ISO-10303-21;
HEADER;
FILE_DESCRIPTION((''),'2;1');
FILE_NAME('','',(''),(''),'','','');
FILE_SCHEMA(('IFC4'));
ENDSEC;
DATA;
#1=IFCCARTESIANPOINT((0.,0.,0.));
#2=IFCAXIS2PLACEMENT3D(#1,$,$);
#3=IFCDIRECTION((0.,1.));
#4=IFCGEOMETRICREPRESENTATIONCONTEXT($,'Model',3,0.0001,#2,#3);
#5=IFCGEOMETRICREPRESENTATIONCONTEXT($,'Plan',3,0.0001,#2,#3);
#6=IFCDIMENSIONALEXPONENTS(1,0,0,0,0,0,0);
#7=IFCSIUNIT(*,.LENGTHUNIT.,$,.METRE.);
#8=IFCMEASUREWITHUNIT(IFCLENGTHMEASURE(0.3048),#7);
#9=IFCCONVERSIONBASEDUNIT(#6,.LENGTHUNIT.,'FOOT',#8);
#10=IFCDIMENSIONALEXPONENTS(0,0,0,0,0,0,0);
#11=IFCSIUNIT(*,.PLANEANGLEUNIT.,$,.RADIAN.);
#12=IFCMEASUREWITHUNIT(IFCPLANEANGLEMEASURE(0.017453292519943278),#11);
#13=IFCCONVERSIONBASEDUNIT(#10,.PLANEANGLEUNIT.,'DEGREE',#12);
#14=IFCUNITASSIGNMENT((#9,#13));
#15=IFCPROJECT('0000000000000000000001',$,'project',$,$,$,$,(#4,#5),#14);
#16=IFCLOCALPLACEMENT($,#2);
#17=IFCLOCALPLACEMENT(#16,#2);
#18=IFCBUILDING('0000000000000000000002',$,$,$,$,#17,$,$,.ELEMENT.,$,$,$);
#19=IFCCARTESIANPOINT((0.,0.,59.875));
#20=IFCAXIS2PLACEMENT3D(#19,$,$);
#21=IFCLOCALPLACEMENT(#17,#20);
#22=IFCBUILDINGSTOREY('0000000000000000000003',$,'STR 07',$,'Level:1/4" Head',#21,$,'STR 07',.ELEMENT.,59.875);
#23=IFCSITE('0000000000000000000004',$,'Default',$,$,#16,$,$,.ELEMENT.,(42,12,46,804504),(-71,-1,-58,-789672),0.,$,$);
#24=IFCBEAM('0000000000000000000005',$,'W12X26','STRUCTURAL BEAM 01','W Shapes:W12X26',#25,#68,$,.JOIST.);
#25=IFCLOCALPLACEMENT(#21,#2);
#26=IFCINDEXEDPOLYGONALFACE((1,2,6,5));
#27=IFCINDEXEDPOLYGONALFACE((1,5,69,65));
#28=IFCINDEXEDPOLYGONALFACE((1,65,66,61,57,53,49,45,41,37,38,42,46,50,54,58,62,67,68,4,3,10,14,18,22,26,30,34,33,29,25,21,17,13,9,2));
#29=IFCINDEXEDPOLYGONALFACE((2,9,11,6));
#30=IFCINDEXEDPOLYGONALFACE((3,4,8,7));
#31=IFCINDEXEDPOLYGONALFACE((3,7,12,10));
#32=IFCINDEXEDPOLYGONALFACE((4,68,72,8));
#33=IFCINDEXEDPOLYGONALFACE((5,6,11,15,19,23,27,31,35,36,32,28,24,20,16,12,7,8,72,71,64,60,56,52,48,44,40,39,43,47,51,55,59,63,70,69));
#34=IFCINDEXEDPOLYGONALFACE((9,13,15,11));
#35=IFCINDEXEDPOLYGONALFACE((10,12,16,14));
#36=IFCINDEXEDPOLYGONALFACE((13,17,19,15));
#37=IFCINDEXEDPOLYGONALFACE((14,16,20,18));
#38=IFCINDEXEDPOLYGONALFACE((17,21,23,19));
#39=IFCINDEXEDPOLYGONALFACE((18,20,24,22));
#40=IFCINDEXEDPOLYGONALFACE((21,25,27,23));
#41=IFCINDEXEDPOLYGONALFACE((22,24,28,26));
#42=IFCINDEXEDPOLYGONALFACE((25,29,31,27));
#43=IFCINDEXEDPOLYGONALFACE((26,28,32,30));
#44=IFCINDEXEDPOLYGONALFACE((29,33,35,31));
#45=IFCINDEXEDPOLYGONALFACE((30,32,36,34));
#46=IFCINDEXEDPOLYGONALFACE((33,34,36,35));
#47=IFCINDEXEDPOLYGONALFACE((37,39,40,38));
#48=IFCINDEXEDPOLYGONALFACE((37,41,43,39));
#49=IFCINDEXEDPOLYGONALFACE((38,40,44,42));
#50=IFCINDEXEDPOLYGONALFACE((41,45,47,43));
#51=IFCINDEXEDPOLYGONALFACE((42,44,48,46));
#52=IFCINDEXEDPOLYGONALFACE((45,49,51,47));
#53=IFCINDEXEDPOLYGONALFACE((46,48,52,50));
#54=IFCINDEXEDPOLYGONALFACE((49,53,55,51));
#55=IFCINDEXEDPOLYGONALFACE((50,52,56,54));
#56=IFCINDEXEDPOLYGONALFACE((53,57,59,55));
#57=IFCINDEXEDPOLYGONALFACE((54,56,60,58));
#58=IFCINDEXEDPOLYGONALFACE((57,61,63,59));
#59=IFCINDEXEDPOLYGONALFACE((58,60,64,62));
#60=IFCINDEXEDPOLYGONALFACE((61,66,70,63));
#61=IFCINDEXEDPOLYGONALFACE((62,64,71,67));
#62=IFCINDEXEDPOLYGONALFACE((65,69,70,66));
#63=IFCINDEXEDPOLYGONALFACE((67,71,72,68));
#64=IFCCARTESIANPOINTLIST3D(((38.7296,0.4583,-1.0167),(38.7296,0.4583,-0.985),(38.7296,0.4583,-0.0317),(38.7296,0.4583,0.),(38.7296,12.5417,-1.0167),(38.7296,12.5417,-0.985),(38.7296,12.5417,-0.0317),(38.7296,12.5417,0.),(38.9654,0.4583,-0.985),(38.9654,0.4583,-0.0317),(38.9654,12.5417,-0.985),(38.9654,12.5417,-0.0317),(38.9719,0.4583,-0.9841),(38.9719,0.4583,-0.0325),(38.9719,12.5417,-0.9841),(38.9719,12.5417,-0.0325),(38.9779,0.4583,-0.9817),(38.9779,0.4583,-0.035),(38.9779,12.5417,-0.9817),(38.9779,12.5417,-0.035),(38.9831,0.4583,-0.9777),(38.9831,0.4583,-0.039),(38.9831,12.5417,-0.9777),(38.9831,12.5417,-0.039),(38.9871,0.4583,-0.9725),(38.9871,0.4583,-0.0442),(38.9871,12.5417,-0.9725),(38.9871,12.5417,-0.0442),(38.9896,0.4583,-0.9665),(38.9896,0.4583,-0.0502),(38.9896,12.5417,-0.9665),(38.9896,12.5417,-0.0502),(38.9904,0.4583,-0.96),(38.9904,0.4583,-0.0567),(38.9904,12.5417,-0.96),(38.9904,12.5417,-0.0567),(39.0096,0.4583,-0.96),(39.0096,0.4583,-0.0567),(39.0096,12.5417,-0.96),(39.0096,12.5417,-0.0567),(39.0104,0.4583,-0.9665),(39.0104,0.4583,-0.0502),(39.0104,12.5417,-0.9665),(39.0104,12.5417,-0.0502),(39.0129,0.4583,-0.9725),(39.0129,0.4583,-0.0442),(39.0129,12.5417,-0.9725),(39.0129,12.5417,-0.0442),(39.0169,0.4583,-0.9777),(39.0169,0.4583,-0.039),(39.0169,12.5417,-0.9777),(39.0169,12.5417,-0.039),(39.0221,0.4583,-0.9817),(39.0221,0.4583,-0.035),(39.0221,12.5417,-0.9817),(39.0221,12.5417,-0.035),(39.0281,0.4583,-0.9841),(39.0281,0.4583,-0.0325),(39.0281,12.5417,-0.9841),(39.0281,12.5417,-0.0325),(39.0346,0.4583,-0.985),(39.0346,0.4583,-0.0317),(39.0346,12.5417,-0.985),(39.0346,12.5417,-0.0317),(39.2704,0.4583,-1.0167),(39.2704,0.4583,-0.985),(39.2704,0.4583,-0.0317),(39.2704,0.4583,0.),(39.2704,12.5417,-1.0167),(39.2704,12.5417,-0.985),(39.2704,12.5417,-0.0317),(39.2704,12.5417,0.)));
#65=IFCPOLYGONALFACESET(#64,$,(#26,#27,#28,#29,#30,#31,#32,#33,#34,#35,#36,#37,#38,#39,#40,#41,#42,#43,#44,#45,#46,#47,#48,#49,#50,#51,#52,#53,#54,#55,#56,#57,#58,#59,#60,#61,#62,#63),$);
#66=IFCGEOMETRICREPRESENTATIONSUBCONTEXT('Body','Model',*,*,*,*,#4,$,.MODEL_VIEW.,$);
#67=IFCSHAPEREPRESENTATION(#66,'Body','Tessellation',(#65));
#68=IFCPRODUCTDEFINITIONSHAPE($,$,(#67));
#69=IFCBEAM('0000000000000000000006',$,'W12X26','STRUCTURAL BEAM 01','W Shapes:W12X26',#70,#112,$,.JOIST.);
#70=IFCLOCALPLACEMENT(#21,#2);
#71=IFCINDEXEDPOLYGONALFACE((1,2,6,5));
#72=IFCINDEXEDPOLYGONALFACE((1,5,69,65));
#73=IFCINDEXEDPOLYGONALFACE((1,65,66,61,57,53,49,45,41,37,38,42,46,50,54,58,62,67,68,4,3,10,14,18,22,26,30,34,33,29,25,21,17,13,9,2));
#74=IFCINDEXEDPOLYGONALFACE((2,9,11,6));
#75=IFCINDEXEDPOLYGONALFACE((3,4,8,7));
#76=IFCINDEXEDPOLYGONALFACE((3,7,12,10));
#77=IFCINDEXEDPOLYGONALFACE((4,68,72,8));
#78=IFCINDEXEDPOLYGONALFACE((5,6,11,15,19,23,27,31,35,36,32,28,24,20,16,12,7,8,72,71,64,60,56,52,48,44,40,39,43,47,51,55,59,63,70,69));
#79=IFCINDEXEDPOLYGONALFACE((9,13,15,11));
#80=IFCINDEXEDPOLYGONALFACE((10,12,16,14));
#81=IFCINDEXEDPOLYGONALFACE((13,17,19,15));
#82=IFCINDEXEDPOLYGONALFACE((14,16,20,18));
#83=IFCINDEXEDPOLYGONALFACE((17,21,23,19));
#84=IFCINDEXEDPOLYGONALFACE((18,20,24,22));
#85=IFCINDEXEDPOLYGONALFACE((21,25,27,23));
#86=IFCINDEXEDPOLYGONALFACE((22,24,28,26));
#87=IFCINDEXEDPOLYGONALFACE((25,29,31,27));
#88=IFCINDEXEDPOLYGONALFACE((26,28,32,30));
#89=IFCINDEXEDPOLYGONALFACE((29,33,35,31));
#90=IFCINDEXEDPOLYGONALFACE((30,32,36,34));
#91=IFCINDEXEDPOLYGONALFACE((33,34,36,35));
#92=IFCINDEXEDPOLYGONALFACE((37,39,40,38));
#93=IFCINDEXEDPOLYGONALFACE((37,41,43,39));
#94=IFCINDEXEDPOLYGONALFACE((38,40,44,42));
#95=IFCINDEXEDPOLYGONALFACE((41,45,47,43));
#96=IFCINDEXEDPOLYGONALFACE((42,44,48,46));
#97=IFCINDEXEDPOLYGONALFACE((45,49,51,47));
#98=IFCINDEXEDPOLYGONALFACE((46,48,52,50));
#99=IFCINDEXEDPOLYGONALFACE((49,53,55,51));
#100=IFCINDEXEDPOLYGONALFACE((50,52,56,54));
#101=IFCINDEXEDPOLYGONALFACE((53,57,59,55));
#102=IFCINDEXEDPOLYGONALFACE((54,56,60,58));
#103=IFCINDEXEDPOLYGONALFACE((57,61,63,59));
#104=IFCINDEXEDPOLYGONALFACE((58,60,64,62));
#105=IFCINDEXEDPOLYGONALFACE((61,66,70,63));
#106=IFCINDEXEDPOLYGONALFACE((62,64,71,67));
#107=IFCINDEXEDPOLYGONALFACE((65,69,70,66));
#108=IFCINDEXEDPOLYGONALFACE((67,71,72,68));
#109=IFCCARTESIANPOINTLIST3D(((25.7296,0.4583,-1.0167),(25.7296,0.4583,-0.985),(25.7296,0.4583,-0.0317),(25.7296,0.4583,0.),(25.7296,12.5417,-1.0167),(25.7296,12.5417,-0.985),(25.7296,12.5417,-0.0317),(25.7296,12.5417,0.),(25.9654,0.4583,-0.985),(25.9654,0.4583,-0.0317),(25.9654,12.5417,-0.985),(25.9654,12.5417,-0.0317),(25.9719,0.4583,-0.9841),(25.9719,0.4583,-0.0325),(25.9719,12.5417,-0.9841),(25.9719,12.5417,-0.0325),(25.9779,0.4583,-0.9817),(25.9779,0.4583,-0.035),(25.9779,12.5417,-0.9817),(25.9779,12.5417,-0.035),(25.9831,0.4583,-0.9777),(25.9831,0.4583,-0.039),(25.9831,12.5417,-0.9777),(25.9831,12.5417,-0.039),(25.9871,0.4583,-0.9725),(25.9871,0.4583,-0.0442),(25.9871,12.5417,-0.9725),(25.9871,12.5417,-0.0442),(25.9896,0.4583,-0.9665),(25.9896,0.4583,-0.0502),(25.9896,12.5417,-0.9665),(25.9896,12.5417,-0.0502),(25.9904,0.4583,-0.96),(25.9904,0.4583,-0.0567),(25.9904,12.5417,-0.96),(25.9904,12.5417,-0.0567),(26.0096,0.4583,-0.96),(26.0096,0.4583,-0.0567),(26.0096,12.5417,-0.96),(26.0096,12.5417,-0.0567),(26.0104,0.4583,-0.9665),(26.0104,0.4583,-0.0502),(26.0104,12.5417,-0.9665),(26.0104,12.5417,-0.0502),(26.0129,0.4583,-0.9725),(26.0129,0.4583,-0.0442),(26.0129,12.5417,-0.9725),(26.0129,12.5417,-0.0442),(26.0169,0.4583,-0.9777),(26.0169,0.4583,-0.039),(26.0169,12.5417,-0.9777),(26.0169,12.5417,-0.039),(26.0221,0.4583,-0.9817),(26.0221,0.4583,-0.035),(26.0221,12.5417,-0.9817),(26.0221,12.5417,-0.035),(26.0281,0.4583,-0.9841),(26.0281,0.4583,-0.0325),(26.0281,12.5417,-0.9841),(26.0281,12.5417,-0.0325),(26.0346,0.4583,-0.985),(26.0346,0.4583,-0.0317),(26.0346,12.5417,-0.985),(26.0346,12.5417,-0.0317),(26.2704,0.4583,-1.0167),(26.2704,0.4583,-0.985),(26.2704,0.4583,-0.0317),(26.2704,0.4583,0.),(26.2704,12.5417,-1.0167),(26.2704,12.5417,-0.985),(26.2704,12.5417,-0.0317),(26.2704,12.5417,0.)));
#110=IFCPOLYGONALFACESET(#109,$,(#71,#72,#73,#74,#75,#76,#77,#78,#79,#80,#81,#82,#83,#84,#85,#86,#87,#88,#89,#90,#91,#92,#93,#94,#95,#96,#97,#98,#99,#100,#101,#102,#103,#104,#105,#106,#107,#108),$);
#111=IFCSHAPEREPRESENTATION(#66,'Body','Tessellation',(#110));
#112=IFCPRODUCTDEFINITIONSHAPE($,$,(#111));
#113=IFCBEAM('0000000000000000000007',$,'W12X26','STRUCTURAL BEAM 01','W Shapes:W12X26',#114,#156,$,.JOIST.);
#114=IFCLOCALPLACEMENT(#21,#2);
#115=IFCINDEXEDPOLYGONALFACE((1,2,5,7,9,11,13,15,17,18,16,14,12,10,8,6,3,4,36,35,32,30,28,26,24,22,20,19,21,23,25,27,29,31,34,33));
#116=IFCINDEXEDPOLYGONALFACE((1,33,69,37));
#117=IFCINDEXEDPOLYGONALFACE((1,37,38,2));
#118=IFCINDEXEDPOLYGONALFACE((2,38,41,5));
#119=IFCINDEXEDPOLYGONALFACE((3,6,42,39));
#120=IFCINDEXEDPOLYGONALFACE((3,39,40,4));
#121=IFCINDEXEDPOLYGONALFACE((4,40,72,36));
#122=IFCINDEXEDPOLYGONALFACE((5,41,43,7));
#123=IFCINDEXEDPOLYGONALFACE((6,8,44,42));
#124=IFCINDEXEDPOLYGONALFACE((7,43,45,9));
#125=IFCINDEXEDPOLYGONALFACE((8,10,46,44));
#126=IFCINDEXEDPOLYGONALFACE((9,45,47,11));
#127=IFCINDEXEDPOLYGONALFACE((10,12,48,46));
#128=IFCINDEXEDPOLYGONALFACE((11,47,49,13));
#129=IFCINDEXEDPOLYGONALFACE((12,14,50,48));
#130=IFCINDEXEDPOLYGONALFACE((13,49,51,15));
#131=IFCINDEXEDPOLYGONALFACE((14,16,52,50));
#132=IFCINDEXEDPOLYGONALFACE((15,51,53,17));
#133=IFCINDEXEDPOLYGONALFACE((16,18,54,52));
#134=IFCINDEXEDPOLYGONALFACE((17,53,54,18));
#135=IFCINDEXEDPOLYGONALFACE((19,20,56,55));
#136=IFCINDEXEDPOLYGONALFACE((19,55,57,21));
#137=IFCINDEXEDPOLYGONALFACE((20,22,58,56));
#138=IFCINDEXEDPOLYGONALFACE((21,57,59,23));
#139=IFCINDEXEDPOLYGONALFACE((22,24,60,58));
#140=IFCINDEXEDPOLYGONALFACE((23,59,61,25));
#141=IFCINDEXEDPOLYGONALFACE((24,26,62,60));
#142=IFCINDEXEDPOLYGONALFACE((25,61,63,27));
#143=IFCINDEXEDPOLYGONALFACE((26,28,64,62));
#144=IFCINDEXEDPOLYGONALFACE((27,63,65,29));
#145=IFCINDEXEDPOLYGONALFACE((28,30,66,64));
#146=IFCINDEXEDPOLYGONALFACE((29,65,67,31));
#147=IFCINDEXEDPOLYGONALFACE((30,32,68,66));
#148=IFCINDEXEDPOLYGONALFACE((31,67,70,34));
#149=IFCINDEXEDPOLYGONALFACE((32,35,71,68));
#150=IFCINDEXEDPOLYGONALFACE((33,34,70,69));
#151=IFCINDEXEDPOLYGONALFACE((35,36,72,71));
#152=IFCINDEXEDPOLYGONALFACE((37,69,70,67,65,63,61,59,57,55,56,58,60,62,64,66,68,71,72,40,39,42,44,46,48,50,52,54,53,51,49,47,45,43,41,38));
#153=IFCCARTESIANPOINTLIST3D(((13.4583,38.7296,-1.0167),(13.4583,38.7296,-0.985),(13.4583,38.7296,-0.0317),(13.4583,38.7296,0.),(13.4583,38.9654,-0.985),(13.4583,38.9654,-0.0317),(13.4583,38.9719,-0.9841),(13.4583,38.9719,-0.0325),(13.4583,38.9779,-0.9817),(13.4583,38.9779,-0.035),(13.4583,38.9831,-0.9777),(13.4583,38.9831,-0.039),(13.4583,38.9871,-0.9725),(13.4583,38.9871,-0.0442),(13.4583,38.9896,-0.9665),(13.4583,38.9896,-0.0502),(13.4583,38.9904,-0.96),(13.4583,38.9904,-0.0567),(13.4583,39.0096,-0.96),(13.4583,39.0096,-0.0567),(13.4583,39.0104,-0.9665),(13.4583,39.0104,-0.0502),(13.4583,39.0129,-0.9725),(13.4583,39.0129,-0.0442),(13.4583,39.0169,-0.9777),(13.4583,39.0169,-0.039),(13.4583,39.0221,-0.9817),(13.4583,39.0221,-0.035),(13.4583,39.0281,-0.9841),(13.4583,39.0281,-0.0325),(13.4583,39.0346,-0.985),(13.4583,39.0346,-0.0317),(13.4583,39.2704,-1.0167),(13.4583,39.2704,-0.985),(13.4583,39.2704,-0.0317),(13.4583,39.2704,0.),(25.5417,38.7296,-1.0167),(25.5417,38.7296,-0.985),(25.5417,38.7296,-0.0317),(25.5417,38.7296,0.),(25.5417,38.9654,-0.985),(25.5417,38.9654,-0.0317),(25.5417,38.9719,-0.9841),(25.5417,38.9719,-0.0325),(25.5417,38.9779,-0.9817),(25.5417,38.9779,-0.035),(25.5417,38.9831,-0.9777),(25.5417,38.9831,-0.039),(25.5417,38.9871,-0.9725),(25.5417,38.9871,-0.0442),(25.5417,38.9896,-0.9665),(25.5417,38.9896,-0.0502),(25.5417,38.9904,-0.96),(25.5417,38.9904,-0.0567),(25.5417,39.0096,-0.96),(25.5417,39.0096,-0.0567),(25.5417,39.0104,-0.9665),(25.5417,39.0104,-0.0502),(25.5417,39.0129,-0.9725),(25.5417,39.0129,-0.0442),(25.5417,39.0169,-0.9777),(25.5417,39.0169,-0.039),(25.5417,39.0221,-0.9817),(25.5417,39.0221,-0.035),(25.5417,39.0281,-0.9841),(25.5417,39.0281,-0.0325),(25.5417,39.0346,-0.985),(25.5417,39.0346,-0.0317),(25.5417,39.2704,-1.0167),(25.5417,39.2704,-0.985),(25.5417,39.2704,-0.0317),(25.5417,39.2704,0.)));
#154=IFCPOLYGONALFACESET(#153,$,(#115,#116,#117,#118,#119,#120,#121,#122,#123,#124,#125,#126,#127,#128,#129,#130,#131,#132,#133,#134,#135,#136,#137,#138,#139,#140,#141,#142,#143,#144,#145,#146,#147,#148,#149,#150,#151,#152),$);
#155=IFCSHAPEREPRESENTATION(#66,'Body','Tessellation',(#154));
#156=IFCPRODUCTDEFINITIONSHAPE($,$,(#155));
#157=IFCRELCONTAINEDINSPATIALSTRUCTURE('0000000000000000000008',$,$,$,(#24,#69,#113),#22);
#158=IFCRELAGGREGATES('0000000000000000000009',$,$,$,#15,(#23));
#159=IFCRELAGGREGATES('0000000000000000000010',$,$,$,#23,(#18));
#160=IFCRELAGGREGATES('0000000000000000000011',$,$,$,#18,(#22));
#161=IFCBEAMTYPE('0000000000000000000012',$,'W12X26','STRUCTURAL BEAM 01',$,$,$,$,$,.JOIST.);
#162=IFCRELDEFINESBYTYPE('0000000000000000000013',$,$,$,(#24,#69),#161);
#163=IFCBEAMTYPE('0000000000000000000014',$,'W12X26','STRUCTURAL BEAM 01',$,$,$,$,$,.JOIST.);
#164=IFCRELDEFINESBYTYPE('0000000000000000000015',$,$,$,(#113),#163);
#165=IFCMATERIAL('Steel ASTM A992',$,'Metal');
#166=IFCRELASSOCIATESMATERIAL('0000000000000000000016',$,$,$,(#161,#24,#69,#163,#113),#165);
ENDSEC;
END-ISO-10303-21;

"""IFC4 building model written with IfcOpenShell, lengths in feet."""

from ifc_helpers import new_model, entity, si_unit, converted_unit, direction, frame, origin, place, context, subcontext, project, spatial, line, arc, indexed_curve, outline, extrude, source, transform, mapped, material, type_object, type_shapes, element, save


model = new_model("IFC4")

# Units and contexts
model_context = context("Model", 3, precision=0.0001, world=origin(), true_north=direction((0.0, 1.0)))
plan_context = context("Plan", 3, precision=0.0001, world=origin(), true_north=direction((0.0, 1.0)))
body_context = subcontext(model_context, "Body", "Model", "MODEL_VIEW")
ifc_project = project(units=[converted_unit("LENGTHUNIT", "FOOT", entity("IfcLengthMeasure", 0.3048), si_unit("LENGTHUNIT", "METRE"), dimensions=[1, 0, 0, 0, 0, 0, 0]), converted_unit("PLANEANGLEUNIT", "DEGREE", entity("IfcPlaneAngleMeasure", 0.017453292519943278), si_unit("PLANEANGLEUNIT", "RADIAN"), dimensions=[0, 0, 0, 0, 0, 0, 0])], contexts=[model_context, plan_context])

# Site, building, storey
site_placement = place(None, origin())
site = spatial("IfcSite", under=ifc_project, at=site_placement, Name="Default", CompositionType="ELEMENT", RefLatitude=(42, 12, 46, 804504), RefLongitude=(-71, -1, -58, -789672), RefElevation=0.0)
building_placement = place(site_placement, origin())
building = spatial("IfcBuilding", under=site, at=building_placement, CompositionType="ELEMENT")
storey_placement = place(building_placement, frame((0.0, 0.0, 59.875)))
storey = spatial("IfcBuildingStorey", under=building, at=storey_placement, Name="STR 07", ObjectType="Level:1/4\" Head", LongName="STR 07", CompositionType="ELEMENT", Elevation=59.875)

# Beams
ifc_material = material(Name="Steel ASTM A992", Category="Metal")
beam_type_1 = type_object("IfcBeamType", Name="W12X26", Description="STRUCTURAL BEAM 01", PredefinedType="JOIST", material=ifc_material)
shared_shape_1 = source(origin(), body_context, "Body", "SweptSolid", [
    extrude(outline(indexed_curve([(-0.2704, -0.4767), (-0.2704, -0.5083), (0.2704, -0.5083), (0.2704, -0.4767), (0.0346, -0.4767), (0.0169, -0.4693), (0.0096, -0.4517), (0.0096, 0.4517), (0.0169, 0.4693), (0.0346, 0.4767), (0.2704, 0.4767), (0.2704, 0.5083), (-0.2704, 0.5083), (-0.2704, 0.4767), (-0.0346, 0.4767), (-0.0169, 0.4693), (-0.0096, 0.4517), (-0.0096, -0.4517), (-0.0169, -0.4693), (-0.0346, -0.4767)], segments=[line(1, 2, 3, 4, 5), arc(5, 6, 7), line(7, 8), arc(8, 9, 10), line(10, 11, 12, 13, 14, 15), arc(15, 16, 17), line(17, 18), arc(18, 19, 20), line(20, 1)], self_intersect=False)), frame((-6.1033, 0.0, 0.0), z_axis=(-1.0, 0.0, 0.0), x_axis=(0.0, -1.0, 0.0)), (0.0, 0.0, -1.0), 12.0833),
])
type_shapes(beam_type_1, [shared_shape_1])
for number, where, z_axis, x_axis, name in (
    (1, (39.0, 6.5617, -0.5083), (0.0, 0.0, 1.0), (0.0, 1.0, 0.0), "W12X26"),
    (2, (26.0, 6.5617, -0.5083), (0.0, 0.0, 1.0), (0.0, 1.0, 0.0), "W12X26"),
):
    element("IfcBeam", number, at=place(storey_placement, frame(where, z_axis=z_axis, x_axis=x_axis)), inside=storey, type_object=beam_type_1, material=ifc_material, Name=name, Description="STRUCTURAL BEAM 01", ObjectType="W Shapes:W12X26", PredefinedType="JOIST", context=body_context, shape_type="MappedRepresentation", body=[
        mapped(shared_shape_1, transform((0.0, 0.0, 0.0), scale=1.0)),
    ])
beam_type_2 = type_object("IfcBeamType", Name="W12X26", Description="STRUCTURAL BEAM 01", PredefinedType="JOIST", material=ifc_material)
shared_shape_2 = source(origin(), body_context, "Body", "SweptSolid", [
    extrude(outline(indexed_curve([(-0.2704, -0.4767), (-0.2704, -0.5083), (0.2704, -0.5083), (0.2704, -0.4767), (0.0346, -0.4767), (0.0169, -0.4693), (0.0096, -0.4517), (0.0096, 0.4517), (0.0169, 0.4693), (0.0346, 0.4767), (0.2704, 0.4767), (0.2704, 0.5083), (-0.2704, 0.5083), (-0.2704, 0.4767), (-0.0346, 0.4767), (-0.0169, 0.4693), (-0.0096, 0.4517), (-0.0096, -0.4517), (-0.0169, -0.4693), (-0.0346, -0.4767)], segments=[line(1, 2, 3, 4, 5), arc(5, 6, 7), line(7, 8), arc(8, 9, 10), line(10, 11, 12, 13, 14, 15), arc(15, 16, 17), line(17, 18), arc(18, 19, 20), line(20, 1)], self_intersect=False)), frame((-6.2267, 0.0, 0.0), z_axis=(-1.0, 0.0, 0.0), x_axis=(0.0, -1.0, 0.0)), (0.0, 0.0, -1.0), 12.0833),
])
type_shapes(beam_type_2, [shared_shape_2])
beam_1_placement = place(storey_placement, frame((19.685, 39.0, -0.5083)))
element("IfcBeam", 3, at=beam_1_placement, inside=storey, type_object=beam_type_2, material=ifc_material, Name="W12X26", Description="STRUCTURAL BEAM 01", ObjectType="W Shapes:W12X26", PredefinedType="JOIST", context=body_context, shape_type="MappedRepresentation", body=[
    mapped(shared_shape_2, transform((0.0, 0.0, 0.0), scale=1.0)),
])

save(model, "model.ifc")
